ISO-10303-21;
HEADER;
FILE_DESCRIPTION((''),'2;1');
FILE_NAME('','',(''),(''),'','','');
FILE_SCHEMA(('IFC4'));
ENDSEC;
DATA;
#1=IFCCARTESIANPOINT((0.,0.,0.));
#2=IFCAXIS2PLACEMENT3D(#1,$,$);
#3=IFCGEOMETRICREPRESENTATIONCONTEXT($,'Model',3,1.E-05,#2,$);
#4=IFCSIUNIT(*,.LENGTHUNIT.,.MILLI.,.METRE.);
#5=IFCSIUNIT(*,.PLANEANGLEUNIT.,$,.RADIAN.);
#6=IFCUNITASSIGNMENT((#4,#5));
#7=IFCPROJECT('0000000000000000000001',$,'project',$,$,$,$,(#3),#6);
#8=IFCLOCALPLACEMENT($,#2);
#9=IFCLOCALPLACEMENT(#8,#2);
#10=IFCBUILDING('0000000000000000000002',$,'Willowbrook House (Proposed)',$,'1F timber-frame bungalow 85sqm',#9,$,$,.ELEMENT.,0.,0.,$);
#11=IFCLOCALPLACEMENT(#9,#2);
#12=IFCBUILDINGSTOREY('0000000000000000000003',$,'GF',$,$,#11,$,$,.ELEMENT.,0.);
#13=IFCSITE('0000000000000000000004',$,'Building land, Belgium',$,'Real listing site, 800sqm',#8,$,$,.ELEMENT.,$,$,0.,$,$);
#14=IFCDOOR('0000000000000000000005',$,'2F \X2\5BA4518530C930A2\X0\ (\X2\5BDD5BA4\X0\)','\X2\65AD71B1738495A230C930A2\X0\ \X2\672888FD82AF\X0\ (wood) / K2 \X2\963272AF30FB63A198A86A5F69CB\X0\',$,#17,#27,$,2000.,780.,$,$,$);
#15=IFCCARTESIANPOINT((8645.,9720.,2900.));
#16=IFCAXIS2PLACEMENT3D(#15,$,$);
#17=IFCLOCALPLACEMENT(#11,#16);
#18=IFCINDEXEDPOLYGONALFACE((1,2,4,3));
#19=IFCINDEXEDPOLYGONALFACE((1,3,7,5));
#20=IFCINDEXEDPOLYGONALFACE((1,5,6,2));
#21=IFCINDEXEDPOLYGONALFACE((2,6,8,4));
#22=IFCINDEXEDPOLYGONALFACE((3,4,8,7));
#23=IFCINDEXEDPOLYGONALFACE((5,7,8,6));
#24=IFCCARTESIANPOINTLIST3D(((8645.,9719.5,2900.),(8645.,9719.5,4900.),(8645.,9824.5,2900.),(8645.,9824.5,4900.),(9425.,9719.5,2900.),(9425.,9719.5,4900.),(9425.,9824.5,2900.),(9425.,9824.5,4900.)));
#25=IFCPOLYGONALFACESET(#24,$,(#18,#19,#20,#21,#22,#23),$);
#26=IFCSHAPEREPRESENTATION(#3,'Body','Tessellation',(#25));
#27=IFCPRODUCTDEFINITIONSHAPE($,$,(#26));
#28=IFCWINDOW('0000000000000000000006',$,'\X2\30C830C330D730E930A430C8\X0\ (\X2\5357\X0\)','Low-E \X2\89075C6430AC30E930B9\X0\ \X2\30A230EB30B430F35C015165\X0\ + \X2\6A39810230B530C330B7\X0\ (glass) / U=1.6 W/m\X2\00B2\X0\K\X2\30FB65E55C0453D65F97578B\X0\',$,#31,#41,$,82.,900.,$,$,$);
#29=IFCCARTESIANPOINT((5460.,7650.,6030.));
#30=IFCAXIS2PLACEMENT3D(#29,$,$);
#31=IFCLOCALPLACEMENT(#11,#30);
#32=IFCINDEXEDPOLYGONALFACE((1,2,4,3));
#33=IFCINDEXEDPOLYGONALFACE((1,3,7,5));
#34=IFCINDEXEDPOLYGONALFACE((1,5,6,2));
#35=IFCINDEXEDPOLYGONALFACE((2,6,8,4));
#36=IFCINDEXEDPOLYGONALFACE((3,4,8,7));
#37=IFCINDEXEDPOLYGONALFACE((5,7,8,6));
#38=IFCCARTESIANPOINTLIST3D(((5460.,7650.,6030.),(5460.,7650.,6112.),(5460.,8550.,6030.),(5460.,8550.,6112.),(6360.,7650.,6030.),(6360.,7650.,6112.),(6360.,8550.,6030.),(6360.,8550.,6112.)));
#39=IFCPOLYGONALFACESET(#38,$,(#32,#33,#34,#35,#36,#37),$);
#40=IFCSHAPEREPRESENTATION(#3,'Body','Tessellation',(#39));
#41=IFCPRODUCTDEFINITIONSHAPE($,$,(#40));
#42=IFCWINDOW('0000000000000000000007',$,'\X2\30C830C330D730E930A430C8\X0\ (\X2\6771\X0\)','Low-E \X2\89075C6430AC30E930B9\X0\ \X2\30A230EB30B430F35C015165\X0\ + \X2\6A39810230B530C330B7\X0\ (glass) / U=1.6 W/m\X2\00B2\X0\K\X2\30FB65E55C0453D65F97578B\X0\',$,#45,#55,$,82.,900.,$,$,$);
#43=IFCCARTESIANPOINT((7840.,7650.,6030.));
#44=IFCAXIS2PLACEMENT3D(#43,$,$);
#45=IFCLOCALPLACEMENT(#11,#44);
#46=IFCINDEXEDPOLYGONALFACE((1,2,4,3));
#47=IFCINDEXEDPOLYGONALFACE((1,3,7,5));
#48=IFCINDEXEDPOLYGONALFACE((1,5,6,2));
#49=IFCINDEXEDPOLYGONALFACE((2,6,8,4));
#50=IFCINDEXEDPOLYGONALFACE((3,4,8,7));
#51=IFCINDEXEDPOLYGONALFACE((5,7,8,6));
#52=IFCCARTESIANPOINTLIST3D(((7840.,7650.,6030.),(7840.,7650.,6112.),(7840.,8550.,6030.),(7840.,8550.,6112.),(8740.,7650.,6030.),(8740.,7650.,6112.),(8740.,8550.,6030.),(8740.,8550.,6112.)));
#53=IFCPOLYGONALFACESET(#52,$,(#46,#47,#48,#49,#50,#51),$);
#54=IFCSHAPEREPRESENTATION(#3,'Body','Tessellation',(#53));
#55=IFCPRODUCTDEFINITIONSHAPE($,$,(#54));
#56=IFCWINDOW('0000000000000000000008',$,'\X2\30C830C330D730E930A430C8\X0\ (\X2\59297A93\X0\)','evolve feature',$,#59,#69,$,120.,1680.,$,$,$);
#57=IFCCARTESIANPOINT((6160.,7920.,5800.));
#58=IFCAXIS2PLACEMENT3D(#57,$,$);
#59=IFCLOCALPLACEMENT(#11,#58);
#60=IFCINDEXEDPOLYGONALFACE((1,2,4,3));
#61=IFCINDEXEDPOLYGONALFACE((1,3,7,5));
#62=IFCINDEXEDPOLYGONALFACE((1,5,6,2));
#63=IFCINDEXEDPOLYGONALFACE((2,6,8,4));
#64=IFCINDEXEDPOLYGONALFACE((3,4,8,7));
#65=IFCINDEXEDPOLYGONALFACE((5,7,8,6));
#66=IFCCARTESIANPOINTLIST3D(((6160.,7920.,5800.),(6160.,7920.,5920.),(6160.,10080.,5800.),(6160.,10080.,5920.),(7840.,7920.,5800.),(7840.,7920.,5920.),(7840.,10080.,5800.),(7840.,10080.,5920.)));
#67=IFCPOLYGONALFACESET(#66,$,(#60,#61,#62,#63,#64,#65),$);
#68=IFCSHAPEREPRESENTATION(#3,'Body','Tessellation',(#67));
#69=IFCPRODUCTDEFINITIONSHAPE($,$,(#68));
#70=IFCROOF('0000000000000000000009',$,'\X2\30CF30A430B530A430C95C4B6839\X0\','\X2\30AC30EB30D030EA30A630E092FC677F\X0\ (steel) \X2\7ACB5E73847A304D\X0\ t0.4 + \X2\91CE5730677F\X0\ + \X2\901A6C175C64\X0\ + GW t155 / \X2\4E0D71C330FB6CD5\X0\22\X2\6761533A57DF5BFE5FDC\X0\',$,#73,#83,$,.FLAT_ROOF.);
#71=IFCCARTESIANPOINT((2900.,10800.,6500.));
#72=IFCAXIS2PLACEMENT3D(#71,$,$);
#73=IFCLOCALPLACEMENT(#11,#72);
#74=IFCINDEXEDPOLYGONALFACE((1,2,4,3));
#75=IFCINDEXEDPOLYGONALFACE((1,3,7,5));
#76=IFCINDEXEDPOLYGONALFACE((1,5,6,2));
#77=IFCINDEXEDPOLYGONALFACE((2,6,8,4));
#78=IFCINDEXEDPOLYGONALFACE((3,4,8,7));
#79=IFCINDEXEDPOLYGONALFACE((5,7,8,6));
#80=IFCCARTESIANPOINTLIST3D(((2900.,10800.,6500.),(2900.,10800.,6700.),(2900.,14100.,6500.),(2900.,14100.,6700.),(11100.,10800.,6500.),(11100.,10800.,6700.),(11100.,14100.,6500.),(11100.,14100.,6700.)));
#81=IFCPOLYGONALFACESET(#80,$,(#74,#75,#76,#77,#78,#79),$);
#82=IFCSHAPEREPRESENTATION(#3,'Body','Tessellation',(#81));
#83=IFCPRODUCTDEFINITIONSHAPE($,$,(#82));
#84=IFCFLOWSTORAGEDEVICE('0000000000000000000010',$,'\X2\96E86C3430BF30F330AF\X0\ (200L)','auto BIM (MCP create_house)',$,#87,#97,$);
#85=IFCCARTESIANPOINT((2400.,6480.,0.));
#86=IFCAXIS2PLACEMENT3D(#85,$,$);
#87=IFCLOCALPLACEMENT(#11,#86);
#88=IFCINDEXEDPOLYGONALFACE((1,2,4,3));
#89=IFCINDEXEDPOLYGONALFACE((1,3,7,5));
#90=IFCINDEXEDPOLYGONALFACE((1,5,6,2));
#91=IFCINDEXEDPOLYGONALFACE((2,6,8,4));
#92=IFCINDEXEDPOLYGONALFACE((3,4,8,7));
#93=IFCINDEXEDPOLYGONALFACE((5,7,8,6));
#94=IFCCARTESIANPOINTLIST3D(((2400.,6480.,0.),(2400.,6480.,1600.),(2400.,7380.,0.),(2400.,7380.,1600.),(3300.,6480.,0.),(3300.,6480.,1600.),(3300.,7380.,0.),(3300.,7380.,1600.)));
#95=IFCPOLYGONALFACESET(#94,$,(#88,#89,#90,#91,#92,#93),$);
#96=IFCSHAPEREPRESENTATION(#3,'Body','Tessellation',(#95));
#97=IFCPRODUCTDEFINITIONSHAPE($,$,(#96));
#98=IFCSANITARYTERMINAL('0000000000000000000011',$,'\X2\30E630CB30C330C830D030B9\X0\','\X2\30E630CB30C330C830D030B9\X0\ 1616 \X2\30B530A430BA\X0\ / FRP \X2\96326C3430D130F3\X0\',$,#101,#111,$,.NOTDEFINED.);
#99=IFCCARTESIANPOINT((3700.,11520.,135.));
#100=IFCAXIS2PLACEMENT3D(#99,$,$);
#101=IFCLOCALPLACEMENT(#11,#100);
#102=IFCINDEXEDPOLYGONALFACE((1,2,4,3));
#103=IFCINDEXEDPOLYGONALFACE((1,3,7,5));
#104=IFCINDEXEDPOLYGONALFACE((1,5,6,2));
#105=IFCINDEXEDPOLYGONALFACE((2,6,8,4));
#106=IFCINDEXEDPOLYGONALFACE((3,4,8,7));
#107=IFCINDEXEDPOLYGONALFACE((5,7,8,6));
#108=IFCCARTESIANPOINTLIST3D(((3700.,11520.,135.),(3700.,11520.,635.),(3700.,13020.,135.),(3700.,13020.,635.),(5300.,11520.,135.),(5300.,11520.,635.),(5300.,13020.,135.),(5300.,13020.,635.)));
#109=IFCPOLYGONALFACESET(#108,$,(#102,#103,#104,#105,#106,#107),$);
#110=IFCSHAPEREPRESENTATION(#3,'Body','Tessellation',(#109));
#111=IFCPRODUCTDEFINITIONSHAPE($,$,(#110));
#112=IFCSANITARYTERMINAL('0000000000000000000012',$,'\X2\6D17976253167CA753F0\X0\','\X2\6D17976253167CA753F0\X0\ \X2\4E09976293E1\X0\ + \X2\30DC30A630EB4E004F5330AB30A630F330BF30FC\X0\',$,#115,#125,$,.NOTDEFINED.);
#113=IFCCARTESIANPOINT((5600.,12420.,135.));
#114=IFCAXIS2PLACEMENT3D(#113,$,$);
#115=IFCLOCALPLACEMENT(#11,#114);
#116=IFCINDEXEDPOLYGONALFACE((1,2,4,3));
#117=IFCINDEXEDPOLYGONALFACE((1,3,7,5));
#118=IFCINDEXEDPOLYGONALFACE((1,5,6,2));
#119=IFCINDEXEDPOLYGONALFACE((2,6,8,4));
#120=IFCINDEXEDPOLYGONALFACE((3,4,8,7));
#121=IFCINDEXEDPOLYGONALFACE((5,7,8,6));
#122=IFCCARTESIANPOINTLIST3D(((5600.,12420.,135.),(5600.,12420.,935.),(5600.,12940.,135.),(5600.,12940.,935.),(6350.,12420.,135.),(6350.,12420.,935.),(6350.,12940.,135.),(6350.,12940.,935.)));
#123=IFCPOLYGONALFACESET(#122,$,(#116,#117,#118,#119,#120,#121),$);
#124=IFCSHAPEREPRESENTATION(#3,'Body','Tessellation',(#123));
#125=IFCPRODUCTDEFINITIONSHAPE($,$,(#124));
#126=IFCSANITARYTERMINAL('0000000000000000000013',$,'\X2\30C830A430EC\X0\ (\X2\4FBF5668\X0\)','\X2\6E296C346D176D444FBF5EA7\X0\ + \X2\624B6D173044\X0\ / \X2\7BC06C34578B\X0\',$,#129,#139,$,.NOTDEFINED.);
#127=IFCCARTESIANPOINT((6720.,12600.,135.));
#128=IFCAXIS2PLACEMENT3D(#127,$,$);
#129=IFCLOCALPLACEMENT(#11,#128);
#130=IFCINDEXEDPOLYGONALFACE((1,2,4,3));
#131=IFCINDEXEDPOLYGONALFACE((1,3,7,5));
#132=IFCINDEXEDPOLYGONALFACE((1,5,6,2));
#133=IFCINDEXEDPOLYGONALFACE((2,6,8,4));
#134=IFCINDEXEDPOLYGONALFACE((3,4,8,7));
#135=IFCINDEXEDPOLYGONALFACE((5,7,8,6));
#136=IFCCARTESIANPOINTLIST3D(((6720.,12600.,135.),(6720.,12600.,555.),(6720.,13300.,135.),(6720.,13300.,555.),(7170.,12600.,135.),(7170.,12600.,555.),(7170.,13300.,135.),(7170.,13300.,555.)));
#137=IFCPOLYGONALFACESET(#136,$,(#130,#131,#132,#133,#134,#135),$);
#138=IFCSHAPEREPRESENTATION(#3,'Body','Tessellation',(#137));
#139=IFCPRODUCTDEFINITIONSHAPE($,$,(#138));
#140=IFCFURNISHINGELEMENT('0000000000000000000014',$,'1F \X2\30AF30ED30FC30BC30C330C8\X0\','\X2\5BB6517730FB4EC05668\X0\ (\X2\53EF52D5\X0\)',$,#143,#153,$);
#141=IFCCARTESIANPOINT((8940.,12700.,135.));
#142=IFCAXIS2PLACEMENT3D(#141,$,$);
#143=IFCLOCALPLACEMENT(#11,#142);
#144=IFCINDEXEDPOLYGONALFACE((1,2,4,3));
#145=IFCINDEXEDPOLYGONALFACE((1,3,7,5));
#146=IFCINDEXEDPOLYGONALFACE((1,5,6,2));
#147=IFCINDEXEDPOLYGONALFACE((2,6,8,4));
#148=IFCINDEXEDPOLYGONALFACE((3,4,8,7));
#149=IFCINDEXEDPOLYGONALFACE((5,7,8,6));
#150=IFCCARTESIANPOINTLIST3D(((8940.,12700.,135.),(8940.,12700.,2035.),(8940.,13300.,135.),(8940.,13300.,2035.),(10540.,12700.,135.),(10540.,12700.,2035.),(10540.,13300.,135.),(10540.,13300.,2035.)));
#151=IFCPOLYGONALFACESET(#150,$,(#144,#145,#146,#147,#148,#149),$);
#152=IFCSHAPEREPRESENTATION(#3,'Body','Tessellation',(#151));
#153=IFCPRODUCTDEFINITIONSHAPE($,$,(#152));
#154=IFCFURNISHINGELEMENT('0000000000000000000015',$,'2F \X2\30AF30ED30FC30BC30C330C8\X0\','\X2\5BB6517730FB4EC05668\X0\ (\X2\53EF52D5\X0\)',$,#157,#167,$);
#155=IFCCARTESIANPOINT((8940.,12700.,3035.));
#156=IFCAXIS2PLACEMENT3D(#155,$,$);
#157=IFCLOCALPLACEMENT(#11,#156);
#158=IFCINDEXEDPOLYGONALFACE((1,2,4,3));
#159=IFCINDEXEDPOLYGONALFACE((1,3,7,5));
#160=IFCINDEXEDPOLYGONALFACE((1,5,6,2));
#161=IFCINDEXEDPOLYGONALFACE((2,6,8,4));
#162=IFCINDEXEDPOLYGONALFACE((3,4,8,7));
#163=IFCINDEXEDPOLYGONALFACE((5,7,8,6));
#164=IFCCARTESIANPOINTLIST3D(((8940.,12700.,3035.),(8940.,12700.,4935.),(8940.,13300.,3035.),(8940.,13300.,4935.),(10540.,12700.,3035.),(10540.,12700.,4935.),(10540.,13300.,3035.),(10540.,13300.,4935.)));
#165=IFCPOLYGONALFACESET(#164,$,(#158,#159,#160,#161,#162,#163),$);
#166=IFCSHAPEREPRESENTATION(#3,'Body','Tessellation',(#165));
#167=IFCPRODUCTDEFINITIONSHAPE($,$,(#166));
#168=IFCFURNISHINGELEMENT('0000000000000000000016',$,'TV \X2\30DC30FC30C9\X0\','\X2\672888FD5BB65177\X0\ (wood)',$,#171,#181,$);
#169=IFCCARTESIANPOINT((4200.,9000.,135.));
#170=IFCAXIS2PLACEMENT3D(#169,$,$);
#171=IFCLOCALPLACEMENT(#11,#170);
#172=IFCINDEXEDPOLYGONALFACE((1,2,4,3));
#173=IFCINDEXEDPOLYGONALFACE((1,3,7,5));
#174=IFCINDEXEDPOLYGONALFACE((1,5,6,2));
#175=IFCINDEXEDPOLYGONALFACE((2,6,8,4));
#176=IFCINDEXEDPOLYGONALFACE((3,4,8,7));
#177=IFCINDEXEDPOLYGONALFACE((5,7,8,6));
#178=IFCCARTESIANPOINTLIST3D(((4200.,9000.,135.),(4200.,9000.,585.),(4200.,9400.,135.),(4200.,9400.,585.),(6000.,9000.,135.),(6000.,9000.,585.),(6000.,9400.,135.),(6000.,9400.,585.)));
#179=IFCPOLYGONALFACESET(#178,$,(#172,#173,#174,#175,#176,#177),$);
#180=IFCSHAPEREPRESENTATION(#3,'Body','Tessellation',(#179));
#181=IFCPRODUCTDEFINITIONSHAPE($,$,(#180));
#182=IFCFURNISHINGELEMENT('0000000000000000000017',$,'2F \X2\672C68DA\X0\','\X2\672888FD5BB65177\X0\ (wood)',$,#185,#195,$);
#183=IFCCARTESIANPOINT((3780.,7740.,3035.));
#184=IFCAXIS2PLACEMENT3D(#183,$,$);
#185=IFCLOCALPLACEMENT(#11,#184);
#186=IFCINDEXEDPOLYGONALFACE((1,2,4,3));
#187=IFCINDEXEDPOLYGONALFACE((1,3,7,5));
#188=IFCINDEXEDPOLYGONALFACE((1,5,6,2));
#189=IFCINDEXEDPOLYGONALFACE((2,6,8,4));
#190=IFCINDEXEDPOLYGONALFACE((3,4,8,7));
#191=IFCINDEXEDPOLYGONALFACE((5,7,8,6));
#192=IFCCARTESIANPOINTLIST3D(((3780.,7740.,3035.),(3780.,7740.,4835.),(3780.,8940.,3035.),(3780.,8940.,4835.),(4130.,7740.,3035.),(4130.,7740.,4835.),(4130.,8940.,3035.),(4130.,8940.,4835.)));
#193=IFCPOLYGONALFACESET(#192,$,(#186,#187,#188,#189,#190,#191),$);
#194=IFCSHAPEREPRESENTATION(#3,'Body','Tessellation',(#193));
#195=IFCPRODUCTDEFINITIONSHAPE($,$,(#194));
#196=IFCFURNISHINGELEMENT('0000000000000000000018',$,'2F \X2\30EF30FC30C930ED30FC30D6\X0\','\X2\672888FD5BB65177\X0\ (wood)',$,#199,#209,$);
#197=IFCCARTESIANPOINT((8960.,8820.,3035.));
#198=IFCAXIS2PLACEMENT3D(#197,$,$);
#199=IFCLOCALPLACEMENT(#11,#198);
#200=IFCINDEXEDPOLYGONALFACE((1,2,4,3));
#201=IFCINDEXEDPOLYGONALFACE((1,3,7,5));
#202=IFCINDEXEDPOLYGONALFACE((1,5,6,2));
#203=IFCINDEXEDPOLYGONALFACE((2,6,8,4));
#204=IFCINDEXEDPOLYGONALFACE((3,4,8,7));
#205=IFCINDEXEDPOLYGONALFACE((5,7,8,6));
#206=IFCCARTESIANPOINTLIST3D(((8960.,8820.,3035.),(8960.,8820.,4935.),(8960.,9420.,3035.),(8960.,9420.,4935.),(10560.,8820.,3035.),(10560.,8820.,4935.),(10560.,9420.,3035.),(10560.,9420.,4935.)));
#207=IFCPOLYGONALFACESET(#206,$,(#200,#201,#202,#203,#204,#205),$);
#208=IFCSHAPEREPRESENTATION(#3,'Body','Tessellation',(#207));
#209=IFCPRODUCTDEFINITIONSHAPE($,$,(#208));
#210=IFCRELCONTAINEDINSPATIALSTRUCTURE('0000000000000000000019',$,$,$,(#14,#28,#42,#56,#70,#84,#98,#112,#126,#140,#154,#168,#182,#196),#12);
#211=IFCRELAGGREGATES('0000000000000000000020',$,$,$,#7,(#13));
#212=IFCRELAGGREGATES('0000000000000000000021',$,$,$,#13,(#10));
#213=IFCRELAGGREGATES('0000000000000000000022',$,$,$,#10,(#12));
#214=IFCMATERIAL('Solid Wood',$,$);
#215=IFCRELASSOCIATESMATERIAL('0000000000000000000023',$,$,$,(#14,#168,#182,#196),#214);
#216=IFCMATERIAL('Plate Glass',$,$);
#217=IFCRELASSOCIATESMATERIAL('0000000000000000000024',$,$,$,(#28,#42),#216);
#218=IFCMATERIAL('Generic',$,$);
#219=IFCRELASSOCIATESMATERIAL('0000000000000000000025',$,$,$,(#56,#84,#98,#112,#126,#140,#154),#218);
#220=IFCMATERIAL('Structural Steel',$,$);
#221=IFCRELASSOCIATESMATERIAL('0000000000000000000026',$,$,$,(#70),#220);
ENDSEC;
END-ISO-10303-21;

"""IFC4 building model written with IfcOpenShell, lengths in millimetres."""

from ifc_helpers import new_model, si_unit, frame, frame_2d, origin, place, context, project, spatial, rectangle, extrude, material, element, save


model = new_model("IFC4")

# Units and contexts
model_context = context("Model", 3, precision=1e-05, world=origin())
ifc_project = project(units=[si_unit("LENGTHUNIT", "METRE", prefix="MILLI"), si_unit("PLANEANGLEUNIT", "RADIAN")], contexts=[model_context])

# Site, building, storey
site_placement = place(None, origin())
site = spatial("IfcSite", under=ifc_project, at=site_placement, Name="Building land, Belgium", ObjectType="Real listing site, 800sqm", CompositionType="ELEMENT", RefElevation=0.0)
building_placement = place(site_placement, origin())
building = spatial("IfcBuilding", under=site, at=building_placement, Name="Willowbrook House (Proposed)", ObjectType="1F timber-frame bungalow 85sqm", CompositionType="ELEMENT", ElevationOfRefHeight=0.0, ElevationOfTerrain=0.0)
storey_placement = place(building_placement, origin())
storey = spatial("IfcBuildingStorey", under=building, at=storey_placement, Name="GF", CompositionType="ELEMENT", Elevation=0.0)

# Shared definitions
ifc_material_1 = material(Name="Solid Wood")
ifc_material_2 = material(Name="Plate Glass")

# Door
door_1_placement = place(storey_placement, frame((8645.0, 9720.0, 2900.0)))
element("IfcDoor", 1, at=door_1_placement, inside=storey, material=ifc_material_1, Name="2F 室内ドア (寝室)", Description="断熱玄関ドア 木製芯 (wood) / K2 防犯・採風機構", OverallHeight=2000.0, OverallWidth=780.0, context=model_context, shape_type="SweptSolid", body=[
    extrude(rectangle(XDim=780.0, YDim=105.0, at=frame_2d((390.0, 52.0))), frame((8645.0, 9720.0, 2900.0)), (0.0, 0.0, 1.0), 2000.0),
])

# Windows
window_1_placement = place(storey_placement, frame((5460.0, 7650.0, 6030.0)))
element("IfcWindow", 2, at=window_1_placement, inside=storey, material=ifc_material_2, Name="トップライト (南)", Description="Low-E 複層ガラス アルゴン封入 + 樹脂サッシ (glass) / U=1.6 W/m²K・日射取得型", OverallHeight=82.0, OverallWidth=900.0, context=model_context, shape_type="SweptSolid", body=[
    extrude(rectangle(XDim=900.0, YDim=900.0, at=frame_2d((450.0, 450.0))), frame((5460.0, 7650.0, 6030.0)), (0.0, 0.0, 1.0), 82.0),
])
window_2_placement = place(storey_placement, frame((7840.0, 7650.0, 6030.0)))
element("IfcWindow", 3, at=window_2_placement, inside=storey, material=ifc_material_2, Name="トップライト (東)", Description="Low-E 複層ガラス アルゴン封入 + 樹脂サッシ (glass) / U=1.6 W/m²K・日射取得型", OverallHeight=82.0, OverallWidth=900.0, context=model_context, shape_type="SweptSolid", body=[
    extrude(rectangle(XDim=900.0, YDim=900.0, at=frame_2d((450.0, 450.0))), frame((7840.0, 7650.0, 6030.0)), (0.0, 0.0, 1.0), 82.0),
])
ifc_material_3 = material(Name="Generic")
window_3_placement = place(storey_placement, frame((6160.0, 7920.0, 5800.0)))
element("IfcWindow", 4, at=window_3_placement, inside=storey, material=ifc_material_3, Name="トップライト (天窓)", Description="evolve feature", OverallHeight=120.0, OverallWidth=1680.0, context=model_context, shape_type="SweptSolid", body=[
    extrude(rectangle(XDim=1680.0, YDim=2160.0, at=frame_2d((840.0, 1080.0))), frame((6160.0, 7920.0, 5800.0)), (0.0, 0.0, 1.0), 120.0),
])

# Roof
ifc_material_4 = material(Name="Structural Steel")
roof_placement = place(storey_placement, frame((2900.0, 10800.0, 6500.0)))
element("IfcRoof", 5, at=roof_placement, inside=storey, material=ifc_material_4, Name="ハイサイド屋根", Description="ガルバリウム鋼板 (steel) 立平葺き t0.4 + 野地板 + 通気層 + GW t155 / 不燃・法22条区域対応", PredefinedType="FLAT_ROOF", context=model_context, shape_type="SweptSolid", body=[
    extrude(rectangle(XDim=8200.0, YDim=3300.0, at=frame_2d((4100.0, 1650.0))), frame((2900.0, 10800.0, 6500.0)), (0.0, 0.0, 1.0), 200.0),
])

# Flow storage device
flow_storage_device_placement = place(storey_placement, frame((2400.0, 6480.0, 0.0)))
element("IfcFlowStorageDevice", 6, at=flow_storage_device_placement, inside=storey, material=ifc_material_3, Name="雨水タンク (200L)", Description="auto BIM (MCP create_house)", context=model_context, shape_type="SweptSolid", body=[
    extrude(rectangle(XDim=900.0, YDim=900.0, at=frame_2d((450.0, 450.0))), frame((2400.0, 6480.0, 0.0)), (0.0, 0.0, 1.0), 1600.0),
])

# Sanitary terminals
sanitary_terminal_1_placement = place(storey_placement, frame((3700.0, 11520.0, 135.0)))
element("IfcSanitaryTerminal", 7, at=sanitary_terminal_1_placement, inside=storey, material=ifc_material_3, Name="ユニットバス", Description="ユニットバス 1616 サイズ / FRP 防水パン", PredefinedType="NOTDEFINED", context=model_context, shape_type="SweptSolid", body=[
    extrude(rectangle(XDim=1600.0, YDim=1500.0, at=frame_2d((800.0, 750.0))), frame((3700.0, 11520.0, 135.0)), (0.0, 0.0, 1.0), 500.0),
])
sanitary_terminal_2_placement = place(storey_placement, frame((5600.0, 12420.0, 135.0)))
element("IfcSanitaryTerminal", 8, at=sanitary_terminal_2_placement, inside=storey, material=ifc_material_3, Name="洗面化粧台", Description="洗面化粧台 三面鏡 + ボウル一体カウンター", PredefinedType="NOTDEFINED", context=model_context, shape_type="SweptSolid", body=[
    extrude(rectangle(XDim=750.0, YDim=520.0, at=frame_2d((375.0, 260.0))), frame((5600.0, 12420.0, 135.0)), (0.0, 0.0, 1.0), 800.0),
])
sanitary_terminal_3_placement = place(storey_placement, frame((6720.0, 12600.0, 135.0)))
element("IfcSanitaryTerminal", 9, at=sanitary_terminal_3_placement, inside=storey, material=ifc_material_3, Name="トイレ (便器)", Description="温水洗浄便座 + 手洗い / 節水型", PredefinedType="NOTDEFINED", context=model_context, shape_type="SweptSolid", body=[
    extrude(rectangle(XDim=450.0, YDim=700.0, at=frame_2d((225.0, 350.0))), frame((6720.0, 12600.0, 135.0)), (0.0, 0.0, 1.0), 420.0),
])

# Furnishing elements
furnishing_1_placement = place(storey_placement, frame((8940.0, 12700.0, 135.0)))
element("IfcFurnishingElement", 10, at=furnishing_1_placement, inside=storey, material=ifc_material_3, Name="1F クローゼット", Description="家具・什器 (可動)", context=model_context, shape_type="SweptSolid", body=[
    extrude(rectangle(XDim=1600.0, YDim=600.0, at=frame_2d((800.0, 300.0))), frame((8940.0, 12700.0, 135.0)), (0.0, 0.0, 1.0), 1900.0),
])
furnishing_2_placement = place(storey_placement, frame((8940.0, 12700.0, 3035.0)))
element("IfcFurnishingElement", 11, at=furnishing_2_placement, inside=storey, material=ifc_material_3, Name="2F クローゼット", Description="家具・什器 (可動)", context=model_context, shape_type="SweptSolid", body=[
    extrude(rectangle(XDim=1600.0, YDim=600.0, at=frame_2d((800.0, 300.0))), frame((8940.0, 12700.0, 3035.0)), (0.0, 0.0, 1.0), 1900.0),
])
furnishing_3_placement = place(storey_placement, frame((4200.0, 9000.0, 135.0)))
element("IfcFurnishingElement", 12, at=furnishing_3_placement, inside=storey, material=ifc_material_1, Name="TV ボード", Description="木製家具 (wood)", context=model_context, shape_type="SweptSolid", body=[
    extrude(rectangle(XDim=1800.0, YDim=400.0, at=frame_2d((900.0, 200.0))), frame((4200.0, 9000.0, 135.0)), (0.0, 0.0, 1.0), 450.0),
])
furnishing_4_placement = place(storey_placement, frame((3780.0, 7740.0, 3035.0)))
element("IfcFurnishingElement", 13, at=furnishing_4_placement, inside=storey, material=ifc_material_1, Name="2F 本棚", Description="木製家具 (wood)", context=model_context, shape_type="SweptSolid", body=[
    extrude(rectangle(XDim=350.0, YDim=1200.0, at=frame_2d((175.0, 600.0))), frame((3780.0, 7740.0, 3035.0)), (0.0, 0.0, 1.0), 1800.0),
])
furnishing_5_placement = place(storey_placement, frame((8960.0, 8820.0, 3035.0)))
element("IfcFurnishingElement", 14, at=furnishing_5_placement, inside=storey, material=ifc_material_1, Name="2F ワードローブ", Description="木製家具 (wood)", context=model_context, shape_type="SweptSolid", body=[
    extrude(rectangle(XDim=1600.0, YDim=600.0, at=frame_2d((800.0, 300.0))), frame((8960.0, 8820.0, 3035.0)), (0.0, 0.0, 1.0), 1900.0),
])

save(model, "model.ifc")
